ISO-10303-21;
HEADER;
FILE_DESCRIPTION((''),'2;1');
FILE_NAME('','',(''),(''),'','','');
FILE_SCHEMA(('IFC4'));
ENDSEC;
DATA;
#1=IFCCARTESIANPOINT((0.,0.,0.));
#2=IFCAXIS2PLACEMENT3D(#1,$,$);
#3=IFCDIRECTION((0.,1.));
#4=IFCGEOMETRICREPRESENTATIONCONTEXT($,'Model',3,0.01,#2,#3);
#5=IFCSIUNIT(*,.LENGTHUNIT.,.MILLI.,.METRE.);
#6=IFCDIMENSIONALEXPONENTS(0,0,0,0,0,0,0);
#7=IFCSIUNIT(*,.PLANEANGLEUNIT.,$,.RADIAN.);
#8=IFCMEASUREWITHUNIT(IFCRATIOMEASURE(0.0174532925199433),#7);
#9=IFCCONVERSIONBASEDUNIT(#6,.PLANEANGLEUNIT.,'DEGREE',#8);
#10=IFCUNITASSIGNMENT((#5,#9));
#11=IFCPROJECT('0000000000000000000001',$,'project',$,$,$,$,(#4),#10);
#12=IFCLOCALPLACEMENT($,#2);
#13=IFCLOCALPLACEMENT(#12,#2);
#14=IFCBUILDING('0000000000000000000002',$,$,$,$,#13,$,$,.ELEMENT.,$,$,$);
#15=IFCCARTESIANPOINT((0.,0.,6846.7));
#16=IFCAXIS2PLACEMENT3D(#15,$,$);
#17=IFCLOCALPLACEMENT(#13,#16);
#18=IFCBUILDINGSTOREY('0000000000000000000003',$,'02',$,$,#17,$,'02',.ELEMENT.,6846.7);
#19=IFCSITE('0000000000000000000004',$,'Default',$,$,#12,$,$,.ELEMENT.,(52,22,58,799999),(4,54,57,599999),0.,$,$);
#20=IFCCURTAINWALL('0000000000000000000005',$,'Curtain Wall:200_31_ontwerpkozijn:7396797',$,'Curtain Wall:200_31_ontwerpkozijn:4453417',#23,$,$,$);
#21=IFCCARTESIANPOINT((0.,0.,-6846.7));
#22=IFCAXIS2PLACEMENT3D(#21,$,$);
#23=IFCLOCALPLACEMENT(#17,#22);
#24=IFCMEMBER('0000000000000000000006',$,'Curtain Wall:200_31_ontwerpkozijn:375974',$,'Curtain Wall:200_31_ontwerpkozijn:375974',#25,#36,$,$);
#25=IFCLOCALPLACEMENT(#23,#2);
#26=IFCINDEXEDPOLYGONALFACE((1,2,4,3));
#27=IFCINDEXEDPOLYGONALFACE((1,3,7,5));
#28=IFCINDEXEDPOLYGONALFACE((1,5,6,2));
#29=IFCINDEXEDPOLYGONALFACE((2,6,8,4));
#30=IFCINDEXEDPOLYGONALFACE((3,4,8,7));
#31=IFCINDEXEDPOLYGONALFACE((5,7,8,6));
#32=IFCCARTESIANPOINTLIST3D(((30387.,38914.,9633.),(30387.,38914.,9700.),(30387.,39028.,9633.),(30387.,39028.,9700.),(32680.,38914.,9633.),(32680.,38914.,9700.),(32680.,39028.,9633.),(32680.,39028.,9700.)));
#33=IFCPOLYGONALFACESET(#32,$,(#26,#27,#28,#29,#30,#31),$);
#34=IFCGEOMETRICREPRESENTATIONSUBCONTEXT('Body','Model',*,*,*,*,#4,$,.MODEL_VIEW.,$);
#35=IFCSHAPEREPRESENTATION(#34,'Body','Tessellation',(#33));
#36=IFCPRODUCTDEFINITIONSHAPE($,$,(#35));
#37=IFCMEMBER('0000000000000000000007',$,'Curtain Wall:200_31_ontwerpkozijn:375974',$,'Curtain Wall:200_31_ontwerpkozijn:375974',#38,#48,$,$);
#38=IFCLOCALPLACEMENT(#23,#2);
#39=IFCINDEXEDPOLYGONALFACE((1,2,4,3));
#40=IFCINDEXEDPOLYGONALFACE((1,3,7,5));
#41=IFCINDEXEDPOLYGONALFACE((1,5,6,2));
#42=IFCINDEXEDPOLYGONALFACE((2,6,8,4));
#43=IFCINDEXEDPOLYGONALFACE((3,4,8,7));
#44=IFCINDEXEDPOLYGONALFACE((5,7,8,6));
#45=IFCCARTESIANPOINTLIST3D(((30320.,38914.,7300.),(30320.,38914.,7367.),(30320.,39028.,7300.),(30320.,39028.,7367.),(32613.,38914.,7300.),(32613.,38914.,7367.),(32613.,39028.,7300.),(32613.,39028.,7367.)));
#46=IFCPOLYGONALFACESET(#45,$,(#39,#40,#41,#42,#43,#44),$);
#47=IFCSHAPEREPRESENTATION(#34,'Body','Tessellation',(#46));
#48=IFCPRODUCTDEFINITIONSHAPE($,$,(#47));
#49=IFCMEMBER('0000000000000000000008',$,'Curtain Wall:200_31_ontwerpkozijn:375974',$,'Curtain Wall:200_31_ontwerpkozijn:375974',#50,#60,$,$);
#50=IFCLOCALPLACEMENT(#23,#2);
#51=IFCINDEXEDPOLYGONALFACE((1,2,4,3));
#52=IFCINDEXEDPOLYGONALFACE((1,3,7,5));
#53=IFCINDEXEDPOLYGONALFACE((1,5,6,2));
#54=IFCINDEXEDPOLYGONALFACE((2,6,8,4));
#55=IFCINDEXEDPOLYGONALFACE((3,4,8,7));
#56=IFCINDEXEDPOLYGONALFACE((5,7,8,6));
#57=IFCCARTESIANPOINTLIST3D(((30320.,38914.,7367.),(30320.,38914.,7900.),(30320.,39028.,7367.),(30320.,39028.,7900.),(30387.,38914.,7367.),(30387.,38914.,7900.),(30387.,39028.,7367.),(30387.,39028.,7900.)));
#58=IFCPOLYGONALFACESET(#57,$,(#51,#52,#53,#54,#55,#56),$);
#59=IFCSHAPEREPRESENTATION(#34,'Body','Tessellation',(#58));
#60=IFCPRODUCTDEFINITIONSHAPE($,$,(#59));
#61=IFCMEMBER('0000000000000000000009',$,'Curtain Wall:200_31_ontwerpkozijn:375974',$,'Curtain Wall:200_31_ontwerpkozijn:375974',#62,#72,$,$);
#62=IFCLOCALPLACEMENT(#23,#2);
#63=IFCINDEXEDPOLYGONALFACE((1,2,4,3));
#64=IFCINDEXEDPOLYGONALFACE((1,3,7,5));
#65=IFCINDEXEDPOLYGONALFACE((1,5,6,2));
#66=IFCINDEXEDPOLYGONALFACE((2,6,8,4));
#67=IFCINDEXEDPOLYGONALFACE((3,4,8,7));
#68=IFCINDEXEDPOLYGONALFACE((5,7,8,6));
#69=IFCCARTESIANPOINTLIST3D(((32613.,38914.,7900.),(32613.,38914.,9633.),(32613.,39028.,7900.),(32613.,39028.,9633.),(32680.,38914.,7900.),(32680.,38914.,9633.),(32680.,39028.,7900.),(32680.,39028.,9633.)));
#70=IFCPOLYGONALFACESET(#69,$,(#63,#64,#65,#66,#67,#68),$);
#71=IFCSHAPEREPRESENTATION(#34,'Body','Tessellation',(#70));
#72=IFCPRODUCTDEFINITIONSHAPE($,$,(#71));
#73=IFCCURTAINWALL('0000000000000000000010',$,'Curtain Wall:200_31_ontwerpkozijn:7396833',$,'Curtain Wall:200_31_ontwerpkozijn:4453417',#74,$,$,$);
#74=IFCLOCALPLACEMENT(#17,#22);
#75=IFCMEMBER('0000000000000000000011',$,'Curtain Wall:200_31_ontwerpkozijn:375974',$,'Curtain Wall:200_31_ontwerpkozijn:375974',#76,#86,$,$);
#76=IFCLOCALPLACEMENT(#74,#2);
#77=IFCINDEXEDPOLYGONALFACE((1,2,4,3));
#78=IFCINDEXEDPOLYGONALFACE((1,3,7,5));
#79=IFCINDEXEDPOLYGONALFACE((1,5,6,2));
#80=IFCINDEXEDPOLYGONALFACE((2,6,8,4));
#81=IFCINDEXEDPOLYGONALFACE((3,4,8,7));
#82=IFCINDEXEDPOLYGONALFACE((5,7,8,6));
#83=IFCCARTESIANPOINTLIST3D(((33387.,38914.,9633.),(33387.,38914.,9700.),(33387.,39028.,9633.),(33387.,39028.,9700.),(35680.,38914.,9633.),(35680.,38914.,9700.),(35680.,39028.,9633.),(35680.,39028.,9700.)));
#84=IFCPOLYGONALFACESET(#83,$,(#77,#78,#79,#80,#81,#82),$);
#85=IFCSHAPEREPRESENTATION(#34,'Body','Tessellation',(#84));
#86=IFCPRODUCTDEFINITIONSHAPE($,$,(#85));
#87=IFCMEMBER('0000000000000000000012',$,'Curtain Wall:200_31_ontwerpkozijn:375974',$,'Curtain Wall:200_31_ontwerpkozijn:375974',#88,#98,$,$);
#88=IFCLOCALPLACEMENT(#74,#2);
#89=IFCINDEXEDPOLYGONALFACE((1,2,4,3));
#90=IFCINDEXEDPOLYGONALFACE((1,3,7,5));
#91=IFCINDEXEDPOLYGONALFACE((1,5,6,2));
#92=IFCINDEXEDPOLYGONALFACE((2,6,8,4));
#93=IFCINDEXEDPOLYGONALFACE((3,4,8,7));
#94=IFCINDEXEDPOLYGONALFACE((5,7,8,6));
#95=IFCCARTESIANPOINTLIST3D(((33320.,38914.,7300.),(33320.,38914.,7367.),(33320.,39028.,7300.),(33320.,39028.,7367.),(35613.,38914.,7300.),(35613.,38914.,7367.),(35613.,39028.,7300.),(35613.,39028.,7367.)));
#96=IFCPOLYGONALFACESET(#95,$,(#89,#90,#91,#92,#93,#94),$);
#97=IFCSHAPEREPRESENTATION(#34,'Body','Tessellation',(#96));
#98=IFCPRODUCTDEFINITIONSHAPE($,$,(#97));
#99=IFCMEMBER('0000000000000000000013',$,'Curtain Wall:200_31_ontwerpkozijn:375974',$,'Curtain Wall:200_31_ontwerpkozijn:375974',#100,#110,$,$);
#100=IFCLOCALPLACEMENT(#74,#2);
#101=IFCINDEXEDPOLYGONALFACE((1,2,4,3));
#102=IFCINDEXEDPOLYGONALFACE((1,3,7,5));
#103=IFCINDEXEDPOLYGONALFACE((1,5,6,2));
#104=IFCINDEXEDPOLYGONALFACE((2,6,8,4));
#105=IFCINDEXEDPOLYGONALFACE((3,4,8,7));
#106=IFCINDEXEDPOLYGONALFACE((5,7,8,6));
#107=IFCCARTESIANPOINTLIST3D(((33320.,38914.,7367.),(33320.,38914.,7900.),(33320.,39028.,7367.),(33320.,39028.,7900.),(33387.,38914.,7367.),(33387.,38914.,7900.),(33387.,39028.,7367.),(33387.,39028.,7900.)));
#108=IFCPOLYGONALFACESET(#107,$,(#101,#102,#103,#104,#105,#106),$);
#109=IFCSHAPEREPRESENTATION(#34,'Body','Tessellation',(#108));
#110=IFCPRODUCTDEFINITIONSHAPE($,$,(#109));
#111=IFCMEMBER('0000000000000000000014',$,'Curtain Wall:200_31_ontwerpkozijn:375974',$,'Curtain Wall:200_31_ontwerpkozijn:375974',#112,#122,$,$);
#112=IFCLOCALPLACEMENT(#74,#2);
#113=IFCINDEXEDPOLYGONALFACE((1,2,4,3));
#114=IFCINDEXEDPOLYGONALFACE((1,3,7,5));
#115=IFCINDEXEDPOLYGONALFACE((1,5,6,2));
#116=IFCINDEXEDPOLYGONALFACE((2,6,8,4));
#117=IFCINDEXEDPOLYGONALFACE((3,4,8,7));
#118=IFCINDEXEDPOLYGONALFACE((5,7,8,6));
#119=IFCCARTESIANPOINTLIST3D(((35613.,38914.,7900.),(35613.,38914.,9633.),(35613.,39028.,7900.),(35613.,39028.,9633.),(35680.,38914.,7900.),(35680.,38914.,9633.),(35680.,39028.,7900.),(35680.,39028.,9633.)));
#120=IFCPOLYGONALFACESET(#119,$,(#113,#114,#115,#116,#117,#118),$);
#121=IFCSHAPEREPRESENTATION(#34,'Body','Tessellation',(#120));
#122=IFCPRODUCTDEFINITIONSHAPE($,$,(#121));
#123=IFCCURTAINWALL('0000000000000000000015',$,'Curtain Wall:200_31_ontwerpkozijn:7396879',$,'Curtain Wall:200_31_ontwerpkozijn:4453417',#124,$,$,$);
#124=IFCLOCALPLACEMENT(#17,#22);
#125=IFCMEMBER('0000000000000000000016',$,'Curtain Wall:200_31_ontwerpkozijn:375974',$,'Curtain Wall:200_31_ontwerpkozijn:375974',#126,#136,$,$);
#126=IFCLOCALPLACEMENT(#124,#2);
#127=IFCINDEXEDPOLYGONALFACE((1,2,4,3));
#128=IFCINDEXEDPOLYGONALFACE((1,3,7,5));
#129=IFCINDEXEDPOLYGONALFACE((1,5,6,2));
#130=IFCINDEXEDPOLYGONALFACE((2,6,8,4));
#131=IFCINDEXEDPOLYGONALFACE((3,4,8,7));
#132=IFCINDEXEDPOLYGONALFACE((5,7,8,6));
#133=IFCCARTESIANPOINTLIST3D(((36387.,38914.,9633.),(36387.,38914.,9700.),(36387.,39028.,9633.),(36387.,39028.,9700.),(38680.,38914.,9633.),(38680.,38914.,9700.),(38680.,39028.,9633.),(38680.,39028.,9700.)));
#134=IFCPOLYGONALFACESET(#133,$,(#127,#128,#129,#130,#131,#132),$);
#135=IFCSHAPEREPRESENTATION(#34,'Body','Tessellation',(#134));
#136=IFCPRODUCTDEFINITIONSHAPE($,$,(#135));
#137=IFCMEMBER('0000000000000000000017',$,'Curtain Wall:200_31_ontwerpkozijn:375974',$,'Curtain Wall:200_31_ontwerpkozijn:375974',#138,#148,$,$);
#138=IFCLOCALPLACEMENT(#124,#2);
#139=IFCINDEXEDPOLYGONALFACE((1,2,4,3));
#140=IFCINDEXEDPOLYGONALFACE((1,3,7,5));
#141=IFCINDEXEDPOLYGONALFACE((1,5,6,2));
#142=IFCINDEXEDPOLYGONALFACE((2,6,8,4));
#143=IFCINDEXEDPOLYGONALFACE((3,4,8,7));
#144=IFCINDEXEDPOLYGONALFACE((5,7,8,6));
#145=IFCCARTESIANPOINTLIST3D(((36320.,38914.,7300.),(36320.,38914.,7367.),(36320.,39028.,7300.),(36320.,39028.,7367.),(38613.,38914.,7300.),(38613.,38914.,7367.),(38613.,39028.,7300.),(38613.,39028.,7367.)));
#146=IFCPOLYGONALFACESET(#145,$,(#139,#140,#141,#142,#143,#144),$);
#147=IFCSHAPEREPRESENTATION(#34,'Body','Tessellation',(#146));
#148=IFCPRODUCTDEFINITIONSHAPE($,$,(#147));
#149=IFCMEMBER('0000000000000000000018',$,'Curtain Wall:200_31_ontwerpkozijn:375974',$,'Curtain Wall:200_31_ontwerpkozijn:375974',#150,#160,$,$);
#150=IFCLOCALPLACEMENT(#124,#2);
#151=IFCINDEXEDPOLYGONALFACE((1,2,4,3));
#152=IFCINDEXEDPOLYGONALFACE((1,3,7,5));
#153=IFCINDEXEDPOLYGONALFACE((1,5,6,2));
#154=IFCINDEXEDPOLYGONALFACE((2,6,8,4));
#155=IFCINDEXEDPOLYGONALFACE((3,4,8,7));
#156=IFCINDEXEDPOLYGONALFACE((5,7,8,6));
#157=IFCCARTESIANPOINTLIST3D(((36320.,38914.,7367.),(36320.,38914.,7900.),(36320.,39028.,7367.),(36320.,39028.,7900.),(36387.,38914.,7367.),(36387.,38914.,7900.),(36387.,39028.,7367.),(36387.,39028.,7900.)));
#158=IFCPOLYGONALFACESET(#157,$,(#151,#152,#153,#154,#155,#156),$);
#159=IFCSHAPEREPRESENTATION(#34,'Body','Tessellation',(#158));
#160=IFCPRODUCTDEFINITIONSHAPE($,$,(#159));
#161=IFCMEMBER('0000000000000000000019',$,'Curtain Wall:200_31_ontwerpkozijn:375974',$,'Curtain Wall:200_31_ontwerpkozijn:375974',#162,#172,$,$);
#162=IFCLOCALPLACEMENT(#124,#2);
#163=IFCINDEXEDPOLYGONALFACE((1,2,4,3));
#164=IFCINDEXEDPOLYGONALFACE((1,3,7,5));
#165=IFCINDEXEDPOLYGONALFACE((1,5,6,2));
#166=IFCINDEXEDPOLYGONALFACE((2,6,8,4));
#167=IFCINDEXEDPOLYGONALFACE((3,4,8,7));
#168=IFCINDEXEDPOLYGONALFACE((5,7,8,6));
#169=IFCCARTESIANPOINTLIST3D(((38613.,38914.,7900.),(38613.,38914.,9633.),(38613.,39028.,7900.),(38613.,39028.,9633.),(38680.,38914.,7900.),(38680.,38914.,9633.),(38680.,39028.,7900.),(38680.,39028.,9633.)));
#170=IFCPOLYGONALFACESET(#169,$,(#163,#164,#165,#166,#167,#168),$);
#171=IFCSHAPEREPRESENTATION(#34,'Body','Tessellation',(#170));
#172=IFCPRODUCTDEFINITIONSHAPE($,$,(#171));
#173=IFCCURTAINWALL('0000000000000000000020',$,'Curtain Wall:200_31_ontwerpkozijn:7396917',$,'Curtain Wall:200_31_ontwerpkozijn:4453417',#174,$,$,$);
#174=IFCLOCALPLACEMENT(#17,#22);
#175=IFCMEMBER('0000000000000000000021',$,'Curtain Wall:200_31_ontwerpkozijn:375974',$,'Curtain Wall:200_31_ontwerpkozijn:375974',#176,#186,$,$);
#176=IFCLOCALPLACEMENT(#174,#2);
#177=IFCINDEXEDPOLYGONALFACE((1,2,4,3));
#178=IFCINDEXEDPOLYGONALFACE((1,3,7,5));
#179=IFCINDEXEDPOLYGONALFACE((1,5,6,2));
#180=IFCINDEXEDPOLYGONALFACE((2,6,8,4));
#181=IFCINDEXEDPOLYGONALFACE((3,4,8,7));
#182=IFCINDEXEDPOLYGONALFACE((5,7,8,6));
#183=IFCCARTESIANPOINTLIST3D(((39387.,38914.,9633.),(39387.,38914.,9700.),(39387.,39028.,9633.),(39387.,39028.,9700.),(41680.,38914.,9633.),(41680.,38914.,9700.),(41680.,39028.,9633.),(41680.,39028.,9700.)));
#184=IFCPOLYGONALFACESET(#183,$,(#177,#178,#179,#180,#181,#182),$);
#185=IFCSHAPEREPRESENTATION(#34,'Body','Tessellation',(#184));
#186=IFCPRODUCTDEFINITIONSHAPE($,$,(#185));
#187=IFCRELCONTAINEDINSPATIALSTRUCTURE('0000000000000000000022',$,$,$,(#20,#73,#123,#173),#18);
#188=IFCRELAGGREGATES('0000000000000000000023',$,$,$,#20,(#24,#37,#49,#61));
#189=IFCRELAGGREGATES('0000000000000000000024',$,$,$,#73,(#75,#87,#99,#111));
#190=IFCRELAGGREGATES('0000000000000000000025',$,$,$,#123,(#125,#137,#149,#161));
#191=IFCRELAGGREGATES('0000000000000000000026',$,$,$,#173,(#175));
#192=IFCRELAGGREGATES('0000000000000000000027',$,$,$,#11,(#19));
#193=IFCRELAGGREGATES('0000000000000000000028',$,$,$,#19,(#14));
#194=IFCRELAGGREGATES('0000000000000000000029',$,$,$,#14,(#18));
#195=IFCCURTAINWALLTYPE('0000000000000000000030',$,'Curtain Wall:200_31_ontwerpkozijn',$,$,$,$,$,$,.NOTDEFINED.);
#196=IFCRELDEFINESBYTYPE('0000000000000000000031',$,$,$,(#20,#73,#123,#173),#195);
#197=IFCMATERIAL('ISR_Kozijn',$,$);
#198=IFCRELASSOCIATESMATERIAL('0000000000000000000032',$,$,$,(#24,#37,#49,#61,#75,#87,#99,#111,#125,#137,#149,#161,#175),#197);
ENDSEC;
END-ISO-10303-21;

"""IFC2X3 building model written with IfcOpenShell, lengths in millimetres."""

from ifc_helpers import new_model, entity, si_unit, converted_unit, direction, frame, frame_2d, origin, origin_2d_with_axis, place, context, subcontext, project, spatial, rectangle, extrude, material, type_object, element, aggregate, save


model = new_model("IFC2X3")

# Units and contexts
model_context = context("Model", 3, precision=0.01, world=origin(), true_north=direction((0.0, 1.0)))
body_context = subcontext(model_context, "Body", "Model", "MODEL_VIEW")
ifc_project = project(units=[si_unit("LENGTHUNIT", "METRE", prefix="MILLI"), converted_unit("PLANEANGLEUNIT", "DEGREE", entity("IfcRatioMeasure", 0.0174532925199433), si_unit("PLANEANGLEUNIT", "RADIAN"), dimensions=[0, 0, 0, 0, 0, 0, 0])], contexts=[model_context])

# Site, building, storey
site_placement = place(None, origin())
site = spatial("IfcSite", under=ifc_project, at=site_placement, Name="Default", CompositionType="ELEMENT", RefLatitude=(52, 22, 58, 799999), RefLongitude=(4, 54, 57, 599999), RefElevation=0.0)
building_placement = place(site_placement, origin())
building = spatial("IfcBuilding", under=site, at=building_placement, CompositionType="ELEMENT")
storey_placement = place(building_placement, frame((0.0, 0.0, 6846.7)))
storey = spatial("IfcBuildingStorey", under=building, at=storey_placement, Name="02", LongName="02", CompositionType="ELEMENT", Elevation=6846.7)

# Curtain walls, members
curtain_wall_type = type_object("IfcCurtainWallType", Name="Curtain Wall:200_31_ontwerpkozijn", PredefinedType="NOTDEFINED")
curtain_wall_1_placement = place(storey_placement, frame((0.0, 0.0, -6846.7)))
curtain_wall_1 = element("IfcCurtainWall", 1, at=curtain_wall_1_placement, inside=storey, type_object=curtain_wall_type, Name="Curtain Wall:200_31_ontwerpkozijn:7396797", ObjectType="Curtain Wall:200_31_ontwerpkozijn:4453417")
ifc_material = material(Name="ISR_Kozijn")
member_1_placement = place(curtain_wall_1_placement, origin())
member_1 = element("IfcMember", 2, at=member_1_placement, material=ifc_material, Name="Curtain Wall:200_31_ontwerpkozijn:375974", ObjectType="Curtain Wall:200_31_ontwerpkozijn:375974", context=body_context, shape_type="SweptSolid", body=[
    extrude(rectangle(XDim=67.0, YDim=114.0, at=frame_2d((0.0, 0.0), x_axis=(1.0, 0.0))), frame((30387.0, 38971.0, 9666.5), z_axis=(1.0, 0.0, 0.0), x_axis=(0.0, 0.0, -1.0)), (0.0, 0.0, 1.0), 2293.0),
])
member_2_placement = place(curtain_wall_1_placement, origin())
member_2 = element("IfcMember", 3, at=member_2_placement, material=ifc_material, Name="Curtain Wall:200_31_ontwerpkozijn:375974", ObjectType="Curtain Wall:200_31_ontwerpkozijn:375974", context=body_context, shape_type="SweptSolid", body=[
    extrude(rectangle(XDim=67.0, YDim=114.0, at=frame_2d((0.0, 0.0), x_axis=(1.0, 0.0))), frame((32613.0, 38971.0, 7333.5), z_axis=(-1.0, 0.0, 0.0), x_axis=(0.0, 0.0, -1.0)), (0.0, 0.0, 1.0), 2293.0),
])
member_3_placement = place(curtain_wall_1_placement, origin())
member_3 = element("IfcMember", 4, at=member_3_placement, material=ifc_material, Name="Curtain Wall:200_31_ontwerpkozijn:375974", ObjectType="Curtain Wall:200_31_ontwerpkozijn:375974", context=body_context, shape_type="SweptSolid", body=[
    extrude(rectangle(XDim=67.0, YDim=114.0, at=frame_2d((0.0, 0.0), x_axis=(1.0, 0.0))), frame((30353.5, 38971.0, 7367.0), z_axis=(0.0, 0.0, 1.0), x_axis=(-1.0, 0.0, 0.0)), (0.0, 0.0, 1.0), 533.0),
])
member_4_placement = place(curtain_wall_1_placement, origin())
member_4 = element("IfcMember", 5, at=member_4_placement, material=ifc_material, Name="Curtain Wall:200_31_ontwerpkozijn:375974", ObjectType="Curtain Wall:200_31_ontwerpkozijn:375974", context=body_context, shape_type="SweptSolid", body=[
    extrude(rectangle(XDim=67.0, YDim=114.0, at=origin_2d_with_axis()), frame((32646.5, 38971.0, 9633.0), z_axis=(0.0, 0.0, -1.0), x_axis=(-1.0, 0.0, 0.0)), (0.0, 0.0, 1.0), 1733.0),
])
aggregate(curtain_wall_1, [member_1, member_2, member_3, member_4])
curtain_wall_2_placement = place(storey_placement, frame((0.0, 0.0, -6846.7)))
curtain_wall_2 = element("IfcCurtainWall", 6, at=curtain_wall_2_placement, inside=storey, type_object=curtain_wall_type, Name="Curtain Wall:200_31_ontwerpkozijn:7396833", ObjectType="Curtain Wall:200_31_ontwerpkozijn:4453417")
member_5_placement = place(curtain_wall_2_placement, origin())
member_5 = element("IfcMember", 7, at=member_5_placement, material=ifc_material, Name="Curtain Wall:200_31_ontwerpkozijn:375974", ObjectType="Curtain Wall:200_31_ontwerpkozijn:375974", context=body_context, shape_type="SweptSolid", body=[
    extrude(rectangle(XDim=67.0, YDim=114.0, at=frame_2d((0.0, 0.0), x_axis=(1.0, 0.0))), frame((33387.0, 38971.0, 9666.5), z_axis=(1.0, 0.0, 0.0), x_axis=(0.0, 0.0, -1.0)), (0.0, 0.0, 1.0), 2293.0),
])
member_6_placement = place(curtain_wall_2_placement, origin())
member_6 = element("IfcMember", 8, at=member_6_placement, material=ifc_material, Name="Curtain Wall:200_31_ontwerpkozijn:375974", ObjectType="Curtain Wall:200_31_ontwerpkozijn:375974", context=body_context, shape_type="SweptSolid", body=[
    extrude(rectangle(XDim=67.0, YDim=114.0, at=frame_2d((0.0, 0.0), x_axis=(1.0, 0.0))), frame((35613.0, 38971.0, 7333.5), z_axis=(-1.0, 0.0, 0.0), x_axis=(0.0, 0.0, -1.0)), (0.0, 0.0, 1.0), 2293.0),
])
member_7_placement = place(curtain_wall_2_placement, origin())
member_7 = element("IfcMember", 9, at=member_7_placement, material=ifc_material, Name="Curtain Wall:200_31_ontwerpkozijn:375974", ObjectType="Curtain Wall:200_31_ontwerpkozijn:375974", context=body_context, shape_type="SweptSolid", body=[
    extrude(rectangle(XDim=67.0, YDim=114.0, at=frame_2d((0.0, 0.0), x_axis=(1.0, 0.0))), frame((33353.5, 38971.0, 7367.0), z_axis=(0.0, 0.0, 1.0), x_axis=(-1.0, 0.0, 0.0)), (0.0, 0.0, 1.0), 533.0),
])
member_8_placement = place(curtain_wall_2_placement, origin())
member_8 = element("IfcMember", 10, at=member_8_placement, material=ifc_material, Name="Curtain Wall:200_31_ontwerpkozijn:375974", ObjectType="Curtain Wall:200_31_ontwerpkozijn:375974", context=body_context, shape_type="SweptSolid", body=[
    extrude(rectangle(XDim=67.0, YDim=114.0, at=frame_2d((0.0, 0.0), x_axis=(1.0, 0.0))), frame((35646.5, 38971.0, 9633.0), z_axis=(0.0, 0.0, -1.0), x_axis=(-1.0, 0.0, 0.0)), (0.0, 0.0, 1.0), 1733.0),
])
aggregate(curtain_wall_2, [member_5, member_6, member_7, member_8])
curtain_wall_3_placement = place(storey_placement, frame((0.0, 0.0, -6846.7)))
curtain_wall_3 = element("IfcCurtainWall", 11, at=curtain_wall_3_placement, inside=storey, type_object=curtain_wall_type, Name="Curtain Wall:200_31_ontwerpkozijn:7396879", ObjectType="Curtain Wall:200_31_ontwerpkozijn:4453417")
member_9_placement = place(curtain_wall_3_placement, origin())
member_9 = element("IfcMember", 12, at=member_9_placement, material=ifc_material, Name="Curtain Wall:200_31_ontwerpkozijn:375974", ObjectType="Curtain Wall:200_31_ontwerpkozijn:375974", context=body_context, shape_type="SweptSolid", body=[
    extrude(rectangle(XDim=67.0, YDim=114.0, at=frame_2d((0.0, 0.0), x_axis=(1.0, 0.0))), frame((36387.0, 38971.0, 9666.5), z_axis=(1.0, 0.0, 0.0), x_axis=(0.0, 0.0, -1.0)), (0.0, 0.0, 1.0), 2293.0),
])
member_10_placement = place(curtain_wall_3_placement, origin())
member_10 = element("IfcMember", 13, at=member_10_placement, material=ifc_material, Name="Curtain Wall:200_31_ontwerpkozijn:375974", ObjectType="Curtain Wall:200_31_ontwerpkozijn:375974", context=body_context, shape_type="SweptSolid", body=[
    extrude(rectangle(XDim=67.0, YDim=114.0, at=frame_2d((0.0, 0.0), x_axis=(1.0, 0.0))), frame((38613.0, 38971.0, 7333.5), z_axis=(-1.0, 0.0, 0.0), x_axis=(0.0, 0.0, -1.0)), (0.0, 0.0, 1.0), 2293.0),
])
member_11_placement = place(curtain_wall_3_placement, origin())
member_11 = element("IfcMember", 14, at=member_11_placement, material=ifc_material, Name="Curtain Wall:200_31_ontwerpkozijn:375974", ObjectType="Curtain Wall:200_31_ontwerpkozijn:375974", context=body_context, shape_type="SweptSolid", body=[
    extrude(rectangle(XDim=67.0, YDim=114.0, at=frame_2d((0.0, 0.0), x_axis=(1.0, 0.0))), frame((36353.5, 38971.0, 7367.0), z_axis=(0.0, 0.0, 1.0), x_axis=(-1.0, 0.0, 0.0)), (0.0, 0.0, 1.0), 533.0),
])
member_12_placement = place(curtain_wall_3_placement, origin())
member_12 = element("IfcMember", 15, at=member_12_placement, material=ifc_material, Name="Curtain Wall:200_31_ontwerpkozijn:375974", ObjectType="Curtain Wall:200_31_ontwerpkozijn:375974", context=body_context, shape_type="SweptSolid", body=[
    extrude(rectangle(XDim=67.0, YDim=114.0, at=origin_2d_with_axis()), frame((38646.5, 38971.0, 9633.0), z_axis=(0.0, 0.0, -1.0), x_axis=(-1.0, 0.0, 0.0)), (0.0, 0.0, 1.0), 1733.0),
])
aggregate(curtain_wall_3, [member_9, member_10, member_11, member_12])
curtain_wall_4_placement = place(storey_placement, frame((0.0, 0.0, -6846.7)))
curtain_wall_4 = element("IfcCurtainWall", 16, at=curtain_wall_4_placement, inside=storey, type_object=curtain_wall_type, Name="Curtain Wall:200_31_ontwerpkozijn:7396917", ObjectType="Curtain Wall:200_31_ontwerpkozijn:4453417")
member_13_placement = place(curtain_wall_4_placement, origin())
member_13 = element("IfcMember", 17, at=member_13_placement, material=ifc_material, Name="Curtain Wall:200_31_ontwerpkozijn:375974", ObjectType="Curtain Wall:200_31_ontwerpkozijn:375974", context=body_context, shape_type="SweptSolid", body=[
    extrude(rectangle(XDim=67.0, YDim=114.0, at=frame_2d((0.0, 0.0), x_axis=(1.0, 0.0))), frame((39387.0, 38971.0, 9666.5), z_axis=(1.0, 0.0, 0.0), x_axis=(0.0, 0.0, -1.0)), (0.0, 0.0, 1.0), 2293.0),
])
aggregate(curtain_wall_4, [member_13])

save(model, "model.ifc")
